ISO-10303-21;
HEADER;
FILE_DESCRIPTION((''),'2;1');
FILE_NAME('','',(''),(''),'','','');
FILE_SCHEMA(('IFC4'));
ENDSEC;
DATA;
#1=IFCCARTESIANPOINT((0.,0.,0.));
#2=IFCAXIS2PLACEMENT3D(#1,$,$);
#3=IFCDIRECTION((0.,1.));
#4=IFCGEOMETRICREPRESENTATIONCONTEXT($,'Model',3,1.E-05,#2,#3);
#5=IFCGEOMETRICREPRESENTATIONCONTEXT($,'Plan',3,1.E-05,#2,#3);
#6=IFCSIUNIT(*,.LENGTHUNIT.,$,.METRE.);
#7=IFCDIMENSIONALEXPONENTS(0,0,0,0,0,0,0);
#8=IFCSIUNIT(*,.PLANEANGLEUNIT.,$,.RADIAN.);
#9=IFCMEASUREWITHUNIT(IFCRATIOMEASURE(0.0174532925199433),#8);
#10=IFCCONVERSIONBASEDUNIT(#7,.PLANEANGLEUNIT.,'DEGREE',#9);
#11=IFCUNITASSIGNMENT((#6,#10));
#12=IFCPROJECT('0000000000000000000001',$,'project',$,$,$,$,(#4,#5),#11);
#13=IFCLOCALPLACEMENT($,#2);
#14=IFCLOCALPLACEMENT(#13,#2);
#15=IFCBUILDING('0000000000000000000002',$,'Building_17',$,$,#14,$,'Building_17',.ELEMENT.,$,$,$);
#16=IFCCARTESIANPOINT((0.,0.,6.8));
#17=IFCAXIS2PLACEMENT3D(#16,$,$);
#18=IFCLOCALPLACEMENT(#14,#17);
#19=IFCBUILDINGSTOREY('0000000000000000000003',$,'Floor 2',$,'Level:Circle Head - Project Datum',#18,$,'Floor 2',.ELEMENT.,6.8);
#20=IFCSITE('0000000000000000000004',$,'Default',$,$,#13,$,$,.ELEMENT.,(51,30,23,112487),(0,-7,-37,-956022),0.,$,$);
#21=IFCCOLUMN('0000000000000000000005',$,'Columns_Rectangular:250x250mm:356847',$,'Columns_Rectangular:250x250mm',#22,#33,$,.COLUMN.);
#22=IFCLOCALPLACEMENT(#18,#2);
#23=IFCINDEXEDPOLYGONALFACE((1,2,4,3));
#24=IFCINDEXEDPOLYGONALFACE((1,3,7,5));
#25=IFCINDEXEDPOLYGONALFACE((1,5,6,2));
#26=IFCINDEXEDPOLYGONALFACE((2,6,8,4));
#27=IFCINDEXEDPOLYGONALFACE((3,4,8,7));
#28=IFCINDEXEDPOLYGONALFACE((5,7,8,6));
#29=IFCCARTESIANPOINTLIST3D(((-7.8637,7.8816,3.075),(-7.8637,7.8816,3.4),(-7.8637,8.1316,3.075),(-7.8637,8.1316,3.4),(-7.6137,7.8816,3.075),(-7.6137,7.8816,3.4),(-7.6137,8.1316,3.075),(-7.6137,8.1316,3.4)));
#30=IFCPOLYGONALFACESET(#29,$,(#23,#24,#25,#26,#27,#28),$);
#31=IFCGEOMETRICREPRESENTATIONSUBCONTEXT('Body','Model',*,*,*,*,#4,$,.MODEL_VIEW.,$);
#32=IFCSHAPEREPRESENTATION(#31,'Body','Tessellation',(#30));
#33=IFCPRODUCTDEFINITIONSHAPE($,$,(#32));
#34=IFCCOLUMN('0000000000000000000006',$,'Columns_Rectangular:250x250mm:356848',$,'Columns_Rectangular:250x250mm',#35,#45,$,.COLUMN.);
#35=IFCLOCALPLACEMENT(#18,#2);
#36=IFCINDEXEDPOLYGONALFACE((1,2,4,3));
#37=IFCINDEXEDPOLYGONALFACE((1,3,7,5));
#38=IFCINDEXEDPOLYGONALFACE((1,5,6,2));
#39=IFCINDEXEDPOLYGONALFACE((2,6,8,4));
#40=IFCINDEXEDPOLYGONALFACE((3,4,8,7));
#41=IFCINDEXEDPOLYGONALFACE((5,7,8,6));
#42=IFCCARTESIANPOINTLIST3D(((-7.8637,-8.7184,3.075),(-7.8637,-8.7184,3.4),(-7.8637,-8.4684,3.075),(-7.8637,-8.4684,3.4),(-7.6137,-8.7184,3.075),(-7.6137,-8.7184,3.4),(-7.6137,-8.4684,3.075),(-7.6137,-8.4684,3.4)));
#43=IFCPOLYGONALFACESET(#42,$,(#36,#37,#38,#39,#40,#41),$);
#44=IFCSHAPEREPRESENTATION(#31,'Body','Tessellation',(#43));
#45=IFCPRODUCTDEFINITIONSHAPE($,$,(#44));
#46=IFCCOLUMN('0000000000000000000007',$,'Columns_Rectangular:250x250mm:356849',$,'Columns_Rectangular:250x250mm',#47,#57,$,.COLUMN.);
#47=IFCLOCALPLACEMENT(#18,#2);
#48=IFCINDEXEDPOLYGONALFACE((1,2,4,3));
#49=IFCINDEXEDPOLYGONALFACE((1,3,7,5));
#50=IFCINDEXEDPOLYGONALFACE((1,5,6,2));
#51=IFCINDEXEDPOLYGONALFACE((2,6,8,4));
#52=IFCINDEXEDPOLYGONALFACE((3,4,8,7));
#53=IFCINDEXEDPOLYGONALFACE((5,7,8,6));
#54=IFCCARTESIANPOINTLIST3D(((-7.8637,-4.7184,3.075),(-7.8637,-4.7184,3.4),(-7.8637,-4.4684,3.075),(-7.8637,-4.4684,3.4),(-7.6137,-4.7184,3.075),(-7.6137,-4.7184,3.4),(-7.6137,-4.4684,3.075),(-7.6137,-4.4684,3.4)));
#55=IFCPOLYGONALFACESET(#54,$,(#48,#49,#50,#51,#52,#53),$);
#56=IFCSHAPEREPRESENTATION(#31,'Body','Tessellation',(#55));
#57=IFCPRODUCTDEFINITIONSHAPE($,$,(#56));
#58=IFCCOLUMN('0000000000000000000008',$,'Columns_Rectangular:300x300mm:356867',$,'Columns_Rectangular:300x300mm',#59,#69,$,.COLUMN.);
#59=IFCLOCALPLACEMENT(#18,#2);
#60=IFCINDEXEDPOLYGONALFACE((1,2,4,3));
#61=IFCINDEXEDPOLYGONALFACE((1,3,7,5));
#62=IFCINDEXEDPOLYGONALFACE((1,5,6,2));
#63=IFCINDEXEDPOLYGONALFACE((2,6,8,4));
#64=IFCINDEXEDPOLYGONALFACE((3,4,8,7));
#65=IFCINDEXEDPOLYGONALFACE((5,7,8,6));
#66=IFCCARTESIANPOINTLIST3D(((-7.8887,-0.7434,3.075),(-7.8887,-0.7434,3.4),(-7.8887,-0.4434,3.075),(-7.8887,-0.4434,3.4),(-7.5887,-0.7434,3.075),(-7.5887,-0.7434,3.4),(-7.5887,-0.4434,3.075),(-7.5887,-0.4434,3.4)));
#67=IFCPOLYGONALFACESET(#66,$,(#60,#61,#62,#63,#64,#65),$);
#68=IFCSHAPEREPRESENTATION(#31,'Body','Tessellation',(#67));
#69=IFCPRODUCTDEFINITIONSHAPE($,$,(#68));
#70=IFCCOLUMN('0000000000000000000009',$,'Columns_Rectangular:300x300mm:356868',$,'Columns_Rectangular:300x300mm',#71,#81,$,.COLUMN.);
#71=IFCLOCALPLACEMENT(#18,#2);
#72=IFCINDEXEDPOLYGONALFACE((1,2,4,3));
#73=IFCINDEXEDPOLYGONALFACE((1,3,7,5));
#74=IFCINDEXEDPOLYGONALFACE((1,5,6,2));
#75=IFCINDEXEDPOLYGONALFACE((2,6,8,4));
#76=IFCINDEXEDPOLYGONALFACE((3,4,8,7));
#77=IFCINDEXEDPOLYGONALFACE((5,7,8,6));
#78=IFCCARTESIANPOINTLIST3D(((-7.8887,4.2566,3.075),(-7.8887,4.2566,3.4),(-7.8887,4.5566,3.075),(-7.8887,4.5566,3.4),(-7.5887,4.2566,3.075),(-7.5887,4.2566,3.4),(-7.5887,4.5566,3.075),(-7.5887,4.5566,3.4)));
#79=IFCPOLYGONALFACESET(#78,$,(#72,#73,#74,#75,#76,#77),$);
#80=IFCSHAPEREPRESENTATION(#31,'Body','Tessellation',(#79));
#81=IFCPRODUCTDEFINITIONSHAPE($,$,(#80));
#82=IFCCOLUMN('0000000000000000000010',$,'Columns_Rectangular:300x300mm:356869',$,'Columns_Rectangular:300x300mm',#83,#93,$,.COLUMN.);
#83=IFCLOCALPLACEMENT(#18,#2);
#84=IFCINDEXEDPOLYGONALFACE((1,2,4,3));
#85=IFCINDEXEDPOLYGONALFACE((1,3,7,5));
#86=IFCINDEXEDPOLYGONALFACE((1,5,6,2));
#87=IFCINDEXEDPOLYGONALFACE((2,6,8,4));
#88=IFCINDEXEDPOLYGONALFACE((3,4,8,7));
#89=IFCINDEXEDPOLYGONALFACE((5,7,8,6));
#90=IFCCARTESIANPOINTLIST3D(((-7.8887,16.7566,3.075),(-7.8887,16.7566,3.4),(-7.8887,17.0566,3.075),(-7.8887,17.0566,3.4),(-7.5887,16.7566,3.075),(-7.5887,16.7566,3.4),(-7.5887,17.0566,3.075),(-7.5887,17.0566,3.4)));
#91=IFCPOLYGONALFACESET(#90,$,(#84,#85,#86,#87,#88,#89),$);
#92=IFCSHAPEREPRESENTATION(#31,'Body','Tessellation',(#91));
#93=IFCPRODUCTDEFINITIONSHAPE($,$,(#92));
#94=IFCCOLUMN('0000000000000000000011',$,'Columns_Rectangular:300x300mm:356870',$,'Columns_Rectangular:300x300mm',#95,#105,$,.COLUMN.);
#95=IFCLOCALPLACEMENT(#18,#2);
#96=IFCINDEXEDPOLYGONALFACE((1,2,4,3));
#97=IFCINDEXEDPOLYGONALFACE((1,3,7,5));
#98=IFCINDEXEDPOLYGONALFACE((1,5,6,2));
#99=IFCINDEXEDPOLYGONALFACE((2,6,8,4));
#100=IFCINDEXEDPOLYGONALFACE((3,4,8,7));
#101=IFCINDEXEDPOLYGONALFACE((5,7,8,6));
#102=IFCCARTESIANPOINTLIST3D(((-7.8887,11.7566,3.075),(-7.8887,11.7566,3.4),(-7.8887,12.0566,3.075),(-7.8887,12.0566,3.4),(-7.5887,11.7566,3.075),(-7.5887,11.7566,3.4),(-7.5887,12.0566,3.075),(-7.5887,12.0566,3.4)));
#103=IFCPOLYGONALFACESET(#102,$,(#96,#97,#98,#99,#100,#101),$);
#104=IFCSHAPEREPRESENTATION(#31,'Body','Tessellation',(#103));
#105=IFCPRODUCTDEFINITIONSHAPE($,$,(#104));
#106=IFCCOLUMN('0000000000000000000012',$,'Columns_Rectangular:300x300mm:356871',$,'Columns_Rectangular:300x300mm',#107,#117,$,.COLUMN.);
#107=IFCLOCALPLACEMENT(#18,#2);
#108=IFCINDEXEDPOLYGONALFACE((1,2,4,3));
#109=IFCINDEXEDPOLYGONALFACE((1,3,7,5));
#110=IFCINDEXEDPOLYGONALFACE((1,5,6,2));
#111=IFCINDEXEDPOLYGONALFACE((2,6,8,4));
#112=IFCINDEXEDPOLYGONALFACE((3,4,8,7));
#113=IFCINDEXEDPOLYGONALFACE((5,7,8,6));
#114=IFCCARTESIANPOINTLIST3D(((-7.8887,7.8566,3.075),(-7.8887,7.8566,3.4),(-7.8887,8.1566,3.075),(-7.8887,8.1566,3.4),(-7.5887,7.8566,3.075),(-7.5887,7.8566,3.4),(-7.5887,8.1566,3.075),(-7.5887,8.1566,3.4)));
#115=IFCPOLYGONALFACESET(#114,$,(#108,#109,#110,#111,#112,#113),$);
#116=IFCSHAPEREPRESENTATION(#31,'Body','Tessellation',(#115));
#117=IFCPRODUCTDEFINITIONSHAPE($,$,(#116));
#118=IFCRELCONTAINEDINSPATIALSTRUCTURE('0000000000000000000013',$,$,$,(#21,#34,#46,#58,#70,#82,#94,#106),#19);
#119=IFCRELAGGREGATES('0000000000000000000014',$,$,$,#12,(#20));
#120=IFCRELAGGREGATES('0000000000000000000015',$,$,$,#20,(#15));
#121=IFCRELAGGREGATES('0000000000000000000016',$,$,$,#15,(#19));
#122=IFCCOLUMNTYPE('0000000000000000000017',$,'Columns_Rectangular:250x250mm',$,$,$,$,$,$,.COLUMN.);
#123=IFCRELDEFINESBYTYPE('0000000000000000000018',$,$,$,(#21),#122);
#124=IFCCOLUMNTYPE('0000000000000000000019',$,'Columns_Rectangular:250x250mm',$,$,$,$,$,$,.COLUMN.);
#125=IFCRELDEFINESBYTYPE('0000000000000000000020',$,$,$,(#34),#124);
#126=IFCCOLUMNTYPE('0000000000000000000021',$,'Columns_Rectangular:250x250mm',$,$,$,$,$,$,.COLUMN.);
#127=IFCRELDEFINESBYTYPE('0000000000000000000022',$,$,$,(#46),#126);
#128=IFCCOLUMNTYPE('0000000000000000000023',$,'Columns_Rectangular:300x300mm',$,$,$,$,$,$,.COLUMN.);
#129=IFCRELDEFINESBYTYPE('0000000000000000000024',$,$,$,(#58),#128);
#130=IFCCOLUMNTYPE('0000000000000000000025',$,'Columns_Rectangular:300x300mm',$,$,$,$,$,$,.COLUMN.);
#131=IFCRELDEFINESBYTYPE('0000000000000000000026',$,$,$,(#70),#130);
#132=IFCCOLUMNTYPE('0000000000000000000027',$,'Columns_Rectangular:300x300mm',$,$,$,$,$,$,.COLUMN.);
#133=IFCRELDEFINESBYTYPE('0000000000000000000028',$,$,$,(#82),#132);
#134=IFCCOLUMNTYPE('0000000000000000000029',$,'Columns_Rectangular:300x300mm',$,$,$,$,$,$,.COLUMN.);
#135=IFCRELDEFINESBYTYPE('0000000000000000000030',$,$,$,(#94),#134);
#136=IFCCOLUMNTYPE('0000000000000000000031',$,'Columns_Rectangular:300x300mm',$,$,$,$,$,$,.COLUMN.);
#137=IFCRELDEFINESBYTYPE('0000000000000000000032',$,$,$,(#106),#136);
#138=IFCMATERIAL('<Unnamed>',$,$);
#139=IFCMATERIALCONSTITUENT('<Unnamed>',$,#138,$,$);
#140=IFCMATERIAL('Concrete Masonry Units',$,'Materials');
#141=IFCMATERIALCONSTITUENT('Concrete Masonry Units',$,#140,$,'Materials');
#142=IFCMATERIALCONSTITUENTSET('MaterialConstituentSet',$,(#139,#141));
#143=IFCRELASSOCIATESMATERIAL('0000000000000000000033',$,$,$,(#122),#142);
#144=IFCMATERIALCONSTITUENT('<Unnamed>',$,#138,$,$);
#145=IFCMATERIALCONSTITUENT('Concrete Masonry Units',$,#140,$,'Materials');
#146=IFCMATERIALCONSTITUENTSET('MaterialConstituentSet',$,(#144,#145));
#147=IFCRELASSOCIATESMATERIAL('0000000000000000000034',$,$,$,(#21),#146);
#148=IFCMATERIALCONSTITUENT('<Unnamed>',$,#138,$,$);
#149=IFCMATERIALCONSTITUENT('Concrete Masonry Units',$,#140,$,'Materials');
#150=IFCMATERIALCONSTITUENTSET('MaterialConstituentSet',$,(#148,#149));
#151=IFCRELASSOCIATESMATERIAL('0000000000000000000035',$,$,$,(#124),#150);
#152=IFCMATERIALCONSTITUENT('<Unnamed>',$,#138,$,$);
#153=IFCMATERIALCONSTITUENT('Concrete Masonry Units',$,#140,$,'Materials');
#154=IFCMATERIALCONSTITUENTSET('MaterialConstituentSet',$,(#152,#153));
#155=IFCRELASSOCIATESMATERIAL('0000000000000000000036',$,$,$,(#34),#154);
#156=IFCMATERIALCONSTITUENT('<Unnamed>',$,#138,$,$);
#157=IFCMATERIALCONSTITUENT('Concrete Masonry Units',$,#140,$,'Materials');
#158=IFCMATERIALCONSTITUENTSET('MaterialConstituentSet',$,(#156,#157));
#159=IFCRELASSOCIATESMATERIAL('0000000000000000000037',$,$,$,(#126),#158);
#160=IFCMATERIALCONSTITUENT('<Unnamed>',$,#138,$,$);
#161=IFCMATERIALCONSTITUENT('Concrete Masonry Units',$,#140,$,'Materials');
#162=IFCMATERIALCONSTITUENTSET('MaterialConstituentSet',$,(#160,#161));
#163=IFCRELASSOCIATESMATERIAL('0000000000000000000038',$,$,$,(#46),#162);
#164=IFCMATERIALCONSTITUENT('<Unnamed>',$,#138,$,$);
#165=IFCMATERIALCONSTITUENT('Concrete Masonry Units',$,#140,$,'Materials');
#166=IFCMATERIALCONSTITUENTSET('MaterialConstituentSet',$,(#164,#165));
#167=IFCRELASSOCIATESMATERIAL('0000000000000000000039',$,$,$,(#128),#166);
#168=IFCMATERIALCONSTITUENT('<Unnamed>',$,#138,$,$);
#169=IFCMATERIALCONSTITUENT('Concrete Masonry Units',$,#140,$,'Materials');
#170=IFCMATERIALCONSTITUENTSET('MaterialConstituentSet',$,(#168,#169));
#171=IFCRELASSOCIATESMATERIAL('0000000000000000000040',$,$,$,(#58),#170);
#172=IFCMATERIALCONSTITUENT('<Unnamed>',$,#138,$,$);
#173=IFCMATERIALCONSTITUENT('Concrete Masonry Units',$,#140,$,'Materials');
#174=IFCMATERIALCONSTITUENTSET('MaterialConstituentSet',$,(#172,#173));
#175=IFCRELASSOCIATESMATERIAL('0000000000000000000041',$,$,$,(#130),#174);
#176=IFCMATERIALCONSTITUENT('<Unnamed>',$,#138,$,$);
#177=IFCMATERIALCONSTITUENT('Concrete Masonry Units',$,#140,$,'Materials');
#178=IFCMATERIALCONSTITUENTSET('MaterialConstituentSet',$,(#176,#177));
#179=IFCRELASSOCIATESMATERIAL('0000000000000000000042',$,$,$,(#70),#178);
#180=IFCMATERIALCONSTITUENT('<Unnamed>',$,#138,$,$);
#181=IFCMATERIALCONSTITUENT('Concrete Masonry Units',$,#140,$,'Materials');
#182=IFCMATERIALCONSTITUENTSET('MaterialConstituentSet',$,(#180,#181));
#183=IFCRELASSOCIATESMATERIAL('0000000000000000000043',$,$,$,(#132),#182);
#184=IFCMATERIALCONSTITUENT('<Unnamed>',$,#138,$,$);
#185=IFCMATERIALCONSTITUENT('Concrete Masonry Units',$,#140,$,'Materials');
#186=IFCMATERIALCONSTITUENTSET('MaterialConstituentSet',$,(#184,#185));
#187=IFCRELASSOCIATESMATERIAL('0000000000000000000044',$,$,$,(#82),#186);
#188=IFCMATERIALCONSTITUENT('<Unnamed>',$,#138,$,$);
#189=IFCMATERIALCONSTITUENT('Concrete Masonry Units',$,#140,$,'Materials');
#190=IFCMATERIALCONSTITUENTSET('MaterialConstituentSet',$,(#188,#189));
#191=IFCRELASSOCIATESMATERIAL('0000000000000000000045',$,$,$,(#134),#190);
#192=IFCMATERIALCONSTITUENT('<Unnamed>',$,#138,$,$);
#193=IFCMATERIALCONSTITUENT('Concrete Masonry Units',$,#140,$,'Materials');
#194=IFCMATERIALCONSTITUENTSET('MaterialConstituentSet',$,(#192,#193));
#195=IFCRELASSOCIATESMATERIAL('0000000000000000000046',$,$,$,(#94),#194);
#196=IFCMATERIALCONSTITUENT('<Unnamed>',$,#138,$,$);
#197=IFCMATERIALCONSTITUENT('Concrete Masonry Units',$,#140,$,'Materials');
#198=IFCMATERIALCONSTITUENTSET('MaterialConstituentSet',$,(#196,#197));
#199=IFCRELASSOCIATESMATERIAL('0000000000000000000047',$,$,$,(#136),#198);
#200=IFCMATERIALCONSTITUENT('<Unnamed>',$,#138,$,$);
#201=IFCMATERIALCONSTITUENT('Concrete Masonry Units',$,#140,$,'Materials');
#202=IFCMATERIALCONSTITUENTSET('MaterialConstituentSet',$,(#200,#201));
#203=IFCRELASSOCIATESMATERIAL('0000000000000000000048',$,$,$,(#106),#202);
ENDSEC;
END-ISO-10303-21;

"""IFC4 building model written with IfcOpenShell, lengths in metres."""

from ifc_helpers import new_model, entity, si_unit, converted_unit, direction, frame, origin, place, context, subcontext, project, spatial, indexed_curve, outline, extrude, source, transform, mapped, material, constituent, constituent_set, type_object, type_shapes, element, save


model = new_model("IFC4")

# Units and contexts
model_context = context("Model", 3, precision=1e-05, world=origin(), true_north=direction((0.0, 1.0)))
plan_context = context("Plan", 3, precision=1e-05, world=origin(), true_north=direction((0.0, 1.0)))
body_context = subcontext(model_context, "Body", "Model", "MODEL_VIEW")
ifc_project = project(units=[si_unit("LENGTHUNIT", "METRE"), converted_unit("PLANEANGLEUNIT", "DEGREE", entity("IfcRatioMeasure", 0.0174532925199433), si_unit("PLANEANGLEUNIT", "RADIAN"), dimensions=[0, 0, 0, 0, 0, 0, 0])], contexts=[model_context, plan_context])

# Site, building, storey
site_placement = place(None, origin())
site = spatial("IfcSite", under=ifc_project, at=site_placement, Name="Default", CompositionType="ELEMENT", RefLatitude=(51, 30, 23, 112487), RefLongitude=(0, -7, -37, -956022), RefElevation=0.0)
building_placement = place(site_placement, origin())
building = spatial("IfcBuilding", under=site, at=building_placement, Name="Building_17", LongName="Building_17", CompositionType="ELEMENT")
storey_placement = place(building_placement, frame((0.0, 0.0, 6.8)))
storey = spatial("IfcBuildingStorey", under=building, at=storey_placement, Name="Floor 2", ObjectType="Level:Circle Head - Project Datum", LongName="Floor 2", CompositionType="ELEMENT", Elevation=6.8)

# Columns
ifc_material_1 = material(Name="<Unnamed>")
ifc_constituent_1 = constituent(ifc_material_1, Name="<Unnamed>")
ifc_material_2 = material(Name="Concrete Masonry Units", Category="Materials")
ifc_constituent_2 = constituent(ifc_material_2, Name="Concrete Masonry Units", Category="Materials")
ifc_constituent_set_1 = constituent_set(constituents=[ifc_constituent_1, ifc_constituent_2], Name="MaterialConstituentSet")
ifc_constituent_3 = constituent(ifc_material_1, Name="<Unnamed>")
ifc_constituent_4 = constituent(ifc_material_2, Name="Concrete Masonry Units", Category="Materials")
ifc_constituent_set_2 = constituent_set(constituents=[ifc_constituent_3, ifc_constituent_4], Name="MaterialConstituentSet")
column_type_1 = type_object("IfcColumnType", Name="Columns_Rectangular:250x250mm", PredefinedType="COLUMN", material=ifc_constituent_set_2)
shared_shape_1 = source(origin(), body_context, "Body", "SweptSolid", [
    extrude(outline(indexed_curve([(-0.125, -0.125), (0.125, -0.125), (0.125, 0.125), (-0.125, 0.125), (-0.125, -0.125)], self_intersect=False)), frame((-7.7387, 8.0066, 9.875), z_axis=(0.0, 0.0, 1.0), x_axis=(0.0, -1.0, 0.0)), (0.0, 0.0, 1.0), 0.325),
])
type_shapes(column_type_1, [shared_shape_1])
column_1_placement = place(storey_placement, frame((0.0, 0.0, -6.8)))
element("IfcColumn", 1, at=column_1_placement, inside=storey, type_object=column_type_1, material=ifc_constituent_set_1, Name="Columns_Rectangular:250x250mm:356847", ObjectType="Columns_Rectangular:250x250mm", PredefinedType="COLUMN", context=body_context, shape_type="MappedRepresentation", body=[
    mapped(shared_shape_1, transform((0.0, 0.0, 0.0), scale=1.0)),
])
ifc_constituent_5 = constituent(ifc_material_1, Name="<Unnamed>")
ifc_constituent_6 = constituent(ifc_material_2, Name="Concrete Masonry Units", Category="Materials")
ifc_constituent_set_3 = constituent_set(constituents=[ifc_constituent_5, ifc_constituent_6], Name="MaterialConstituentSet")
ifc_constituent_7 = constituent(ifc_material_1, Name="<Unnamed>")
ifc_constituent_8 = constituent(ifc_material_2, Name="Concrete Masonry Units", Category="Materials")
ifc_constituent_set_4 = constituent_set(constituents=[ifc_constituent_7, ifc_constituent_8], Name="MaterialConstituentSet")
column_type_2 = type_object("IfcColumnType", Name="Columns_Rectangular:250x250mm", PredefinedType="COLUMN", material=ifc_constituent_set_4)
shared_shape_2 = source(origin(), body_context, "Body", "SweptSolid", [
    extrude(outline(indexed_curve([(-0.125, -0.125), (0.125, -0.125), (0.125, 0.125), (-0.125, 0.125), (-0.125, -0.125)], self_intersect=False)), frame((-7.7387, -8.5934, 9.875), z_axis=(0.0, 0.0, 1.0), x_axis=(0.0, -1.0, 0.0)), (0.0, 0.0, 1.0), 0.325),
])
type_shapes(column_type_2, [shared_shape_2])
column_2_placement = place(storey_placement, frame((0.0, 0.0, -6.8)))
element("IfcColumn", 2, at=column_2_placement, inside=storey, type_object=column_type_2, material=ifc_constituent_set_3, Name="Columns_Rectangular:250x250mm:356848", ObjectType="Columns_Rectangular:250x250mm", PredefinedType="COLUMN", context=body_context, shape_type="MappedRepresentation", body=[
    mapped(shared_shape_2, transform((0.0, 0.0, 0.0), scale=1.0)),
])
ifc_constituent_9 = constituent(ifc_material_1, Name="<Unnamed>")
ifc_constituent_10 = constituent(ifc_material_2, Name="Concrete Masonry Units", Category="Materials")
ifc_constituent_set_5 = constituent_set(constituents=[ifc_constituent_9, ifc_constituent_10], Name="MaterialConstituentSet")
ifc_constituent_11 = constituent(ifc_material_1, Name="<Unnamed>")
ifc_constituent_12 = constituent(ifc_material_2, Name="Concrete Masonry Units", Category="Materials")
ifc_constituent_set_6 = constituent_set(constituents=[ifc_constituent_11, ifc_constituent_12], Name="MaterialConstituentSet")
column_type_3 = type_object("IfcColumnType", Name="Columns_Rectangular:250x250mm", PredefinedType="COLUMN", material=ifc_constituent_set_6)
shared_shape_3 = source(origin(), body_context, "Body", "SweptSolid", [
    extrude(outline(indexed_curve([(-0.125, -0.125), (0.125, -0.125), (0.125, 0.125), (-0.125, 0.125), (-0.125, -0.125)], self_intersect=False)), frame((-7.7387, -4.5934, 9.875), z_axis=(0.0, 0.0, 1.0), x_axis=(0.0, -1.0, 0.0)), (0.0, 0.0, 1.0), 0.325),
])
type_shapes(column_type_3, [shared_shape_3])
column_3_placement = place(storey_placement, frame((0.0, 0.0, -6.8)))
element("IfcColumn", 3, at=column_3_placement, inside=storey, type_object=column_type_3, material=ifc_constituent_set_5, Name="Columns_Rectangular:250x250mm:356849", ObjectType="Columns_Rectangular:250x250mm", PredefinedType="COLUMN", context=body_context, shape_type="MappedRepresentation", body=[
    mapped(shared_shape_3, transform((0.0, 0.0, 0.0), scale=1.0)),
])
ifc_constituent_13 = constituent(ifc_material_1, Name="<Unnamed>")
ifc_constituent_14 = constituent(ifc_material_2, Name="Concrete Masonry Units", Category="Materials")
ifc_constituent_set_7 = constituent_set(constituents=[ifc_constituent_13, ifc_constituent_14], Name="MaterialConstituentSet")
ifc_constituent_15 = constituent(ifc_material_1, Name="<Unnamed>")
ifc_constituent_16 = constituent(ifc_material_2, Name="Concrete Masonry Units", Category="Materials")
ifc_constituent_set_8 = constituent_set(constituents=[ifc_constituent_15, ifc_constituent_16], Name="MaterialConstituentSet")
column_type_4 = type_object("IfcColumnType", Name="Columns_Rectangular:300x300mm", PredefinedType="COLUMN", material=ifc_constituent_set_8)
shared_shape_4 = source(origin(), body_context, "Body", "SweptSolid", [
    extrude(outline(indexed_curve([(-0.15, -0.15), (0.15, -0.15), (0.15, 0.15), (-0.15, 0.15), (-0.15, -0.15)], self_intersect=False)), frame((-7.7387, -0.5934, 9.875), z_axis=(0.0, 0.0, 1.0), x_axis=(0.0, -1.0, 0.0)), (0.0, 0.0, 1.0), 0.325),
])
type_shapes(column_type_4, [shared_shape_4])
column_4_placement = place(storey_placement, frame((0.0, 0.0, -6.8)))
element("IfcColumn", 4, at=column_4_placement, inside=storey, type_object=column_type_4, material=ifc_constituent_set_7, Name="Columns_Rectangular:300x300mm:356867", ObjectType="Columns_Rectangular:300x300mm", PredefinedType="COLUMN", context=body_context, shape_type="MappedRepresentation", body=[
    mapped(shared_shape_4, transform((0.0, 0.0, 0.0), scale=1.0)),
])
ifc_constituent_17 = constituent(ifc_material_1, Name="<Unnamed>")
ifc_constituent_18 = constituent(ifc_material_2, Name="Concrete Masonry Units", Category="Materials")
ifc_constituent_set_9 = constituent_set(constituents=[ifc_constituent_17, ifc_constituent_18], Name="MaterialConstituentSet")
ifc_constituent_19 = constituent(ifc_material_1, Name="<Unnamed>")
ifc_constituent_20 = constituent(ifc_material_2, Name="Concrete Masonry Units", Category="Materials")
ifc_constituent_set_10 = constituent_set(constituents=[ifc_constituent_19, ifc_constituent_20], Name="MaterialConstituentSet")
column_type_5 = type_object("IfcColumnType", Name="Columns_Rectangular:300x300mm", PredefinedType="COLUMN", material=ifc_constituent_set_10)
shared_shape_5 = source(origin(), body_context, "Body", "SweptSolid", [
    extrude(outline(indexed_curve([(-0.15, -0.15), (0.15, -0.15), (0.15, 0.15), (-0.15, 0.15), (-0.15, -0.15)], self_intersect=False)), frame((-7.7387, 4.4066, 9.875), z_axis=(0.0, 0.0, 1.0), x_axis=(0.0, -1.0, 0.0)), (0.0, 0.0, 1.0), 0.325),
])
type_shapes(column_type_5, [shared_shape_5])
column_5_placement = place(storey_placement, frame((0.0, 0.0, -6.8)))
element("IfcColumn", 5, at=column_5_placement, inside=storey, type_object=column_type_5, material=ifc_constituent_set_9, Name="Columns_Rectangular:300x300mm:356868", ObjectType="Columns_Rectangular:300x300mm", PredefinedType="COLUMN", context=body_context, shape_type="MappedRepresentation", body=[
    mapped(shared_shape_5, transform((0.0, 0.0, 0.0), scale=1.0)),
])
ifc_constituent_21 = constituent(ifc_material_1, Name="<Unnamed>")
ifc_constituent_22 = constituent(ifc_material_2, Name="Concrete Masonry Units", Category="Materials")
ifc_constituent_set_11 = constituent_set(constituents=[ifc_constituent_21, ifc_constituent_22], Name="MaterialConstituentSet")
ifc_constituent_23 = constituent(ifc_material_1, Name="<Unnamed>")
ifc_constituent_24 = constituent(ifc_material_2, Name="Concrete Masonry Units", Category="Materials")
ifc_constituent_set_12 = constituent_set(constituents=[ifc_constituent_23, ifc_constituent_24], Name="MaterialConstituentSet")
column_type_6 = type_object("IfcColumnType", Name="Columns_Rectangular:300x300mm", PredefinedType="COLUMN", material=ifc_constituent_set_12)
shared_shape_6 = source(origin(), body_context, "Body", "SweptSolid", [
    extrude(outline(indexed_curve([(-0.15, -0.15), (0.15, -0.15), (0.15, 0.15), (-0.15, 0.15), (-0.15, -0.15)], self_intersect=False)), frame((-7.7387, 16.9066, 9.875), z_axis=(0.0, 0.0, 1.0), x_axis=(0.0, -1.0, 0.0)), (0.0, 0.0, 1.0), 0.325),
])
type_shapes(column_type_6, [shared_shape_6])
column_6_placement = place(storey_placement, frame((0.0, 0.0, -6.8)))
element("IfcColumn", 6, at=column_6_placement, inside=storey, type_object=column_type_6, material=ifc_constituent_set_11, Name="Columns_Rectangular:300x300mm:356869", ObjectType="Columns_Rectangular:300x300mm", PredefinedType="COLUMN", context=body_context, shape_type="MappedRepresentation", body=[
    mapped(shared_shape_6, transform((0.0, 0.0, 0.0), scale=1.0)),
])
ifc_constituent_25 = constituent(ifc_material_1, Name="<Unnamed>")
ifc_constituent_26 = constituent(ifc_material_2, Name="Concrete Masonry Units", Category="Materials")
ifc_constituent_set_13 = constituent_set(constituents=[ifc_constituent_25, ifc_constituent_26], Name="MaterialConstituentSet")
ifc_constituent_27 = constituent(ifc_material_1, Name="<Unnamed>")
ifc_constituent_28 = constituent(ifc_material_2, Name="Concrete Masonry Units", Category="Materials")
ifc_constituent_set_14 = constituent_set(constituents=[ifc_constituent_27, ifc_constituent_28], Name="MaterialConstituentSet")
column_type_7 = type_object("IfcColumnType", Name="Columns_Rectangular:300x300mm", PredefinedType="COLUMN", material=ifc_constituent_set_14)
shared_shape_7 = source(origin(), body_context, "Body", "SweptSolid", [
    extrude(outline(indexed_curve([(-0.15, -0.15), (0.15, -0.15), (0.15, 0.15), (-0.15, 0.15), (-0.15, -0.15)], self_intersect=False)), frame((-7.7387, 11.9066, 9.875), z_axis=(0.0, 0.0, 1.0), x_axis=(0.0, -1.0, 0.0)), (0.0, 0.0, 1.0), 0.325),
])
type_shapes(column_type_7, [shared_shape_7])
column_7_placement = place(storey_placement, frame((0.0, 0.0, -6.8)))
element("IfcColumn", 7, at=column_7_placement, inside=storey, type_object=column_type_7, material=ifc_constituent_set_13, Name="Columns_Rectangular:300x300mm:356870", ObjectType="Columns_Rectangular:300x300mm", PredefinedType="COLUMN", context=body_context, shape_type="MappedRepresentation", body=[
    mapped(shared_shape_7, transform((0.0, 0.0, 0.0), scale=1.0)),
])
ifc_constituent_29 = constituent(ifc_material_1, Name="<Unnamed>")
ifc_constituent_30 = constituent(ifc_material_2, Name="Concrete Masonry Units", Category="Materials")
ifc_constituent_set_15 = constituent_set(constituents=[ifc_constituent_29, ifc_constituent_30], Name="MaterialConstituentSet")
ifc_constituent_31 = constituent(ifc_material_1, Name="<Unnamed>")
ifc_constituent_32 = constituent(ifc_material_2, Name="Concrete Masonry Units", Category="Materials")
ifc_constituent_set_16 = constituent_set(constituents=[ifc_constituent_31, ifc_constituent_32], Name="MaterialConstituentSet")
column_type_8 = type_object("IfcColumnType", Name="Columns_Rectangular:300x300mm", PredefinedType="COLUMN", material=ifc_constituent_set_16)
shared_shape_8 = source(origin(), body_context, "Body", "SweptSolid", [
    extrude(outline(indexed_curve([(-0.15, -0.15), (0.15, -0.15), (0.15, 0.15), (-0.15, 0.15), (-0.15, -0.15)], self_intersect=False)), frame((-7.7387, 8.0066, 9.875), z_axis=(0.0, 0.0, 1.0), x_axis=(0.0, -1.0, 0.0)), (0.0, 0.0, 1.0), 0.325),
])
type_shapes(column_type_8, [shared_shape_8])
column_8_placement = place(storey_placement, frame((0.0, 0.0, -6.8)))
element("IfcColumn", 8, at=column_8_placement, inside=storey, type_object=column_type_8, material=ifc_constituent_set_15, Name="Columns_Rectangular:300x300mm:356871", ObjectType="Columns_Rectangular:300x300mm", PredefinedType="COLUMN", context=body_context, shape_type="MappedRepresentation", body=[
    mapped(shared_shape_8, transform((0.0, 0.0, 0.0), scale=1.0)),
])

save(model, "model.ifc")
